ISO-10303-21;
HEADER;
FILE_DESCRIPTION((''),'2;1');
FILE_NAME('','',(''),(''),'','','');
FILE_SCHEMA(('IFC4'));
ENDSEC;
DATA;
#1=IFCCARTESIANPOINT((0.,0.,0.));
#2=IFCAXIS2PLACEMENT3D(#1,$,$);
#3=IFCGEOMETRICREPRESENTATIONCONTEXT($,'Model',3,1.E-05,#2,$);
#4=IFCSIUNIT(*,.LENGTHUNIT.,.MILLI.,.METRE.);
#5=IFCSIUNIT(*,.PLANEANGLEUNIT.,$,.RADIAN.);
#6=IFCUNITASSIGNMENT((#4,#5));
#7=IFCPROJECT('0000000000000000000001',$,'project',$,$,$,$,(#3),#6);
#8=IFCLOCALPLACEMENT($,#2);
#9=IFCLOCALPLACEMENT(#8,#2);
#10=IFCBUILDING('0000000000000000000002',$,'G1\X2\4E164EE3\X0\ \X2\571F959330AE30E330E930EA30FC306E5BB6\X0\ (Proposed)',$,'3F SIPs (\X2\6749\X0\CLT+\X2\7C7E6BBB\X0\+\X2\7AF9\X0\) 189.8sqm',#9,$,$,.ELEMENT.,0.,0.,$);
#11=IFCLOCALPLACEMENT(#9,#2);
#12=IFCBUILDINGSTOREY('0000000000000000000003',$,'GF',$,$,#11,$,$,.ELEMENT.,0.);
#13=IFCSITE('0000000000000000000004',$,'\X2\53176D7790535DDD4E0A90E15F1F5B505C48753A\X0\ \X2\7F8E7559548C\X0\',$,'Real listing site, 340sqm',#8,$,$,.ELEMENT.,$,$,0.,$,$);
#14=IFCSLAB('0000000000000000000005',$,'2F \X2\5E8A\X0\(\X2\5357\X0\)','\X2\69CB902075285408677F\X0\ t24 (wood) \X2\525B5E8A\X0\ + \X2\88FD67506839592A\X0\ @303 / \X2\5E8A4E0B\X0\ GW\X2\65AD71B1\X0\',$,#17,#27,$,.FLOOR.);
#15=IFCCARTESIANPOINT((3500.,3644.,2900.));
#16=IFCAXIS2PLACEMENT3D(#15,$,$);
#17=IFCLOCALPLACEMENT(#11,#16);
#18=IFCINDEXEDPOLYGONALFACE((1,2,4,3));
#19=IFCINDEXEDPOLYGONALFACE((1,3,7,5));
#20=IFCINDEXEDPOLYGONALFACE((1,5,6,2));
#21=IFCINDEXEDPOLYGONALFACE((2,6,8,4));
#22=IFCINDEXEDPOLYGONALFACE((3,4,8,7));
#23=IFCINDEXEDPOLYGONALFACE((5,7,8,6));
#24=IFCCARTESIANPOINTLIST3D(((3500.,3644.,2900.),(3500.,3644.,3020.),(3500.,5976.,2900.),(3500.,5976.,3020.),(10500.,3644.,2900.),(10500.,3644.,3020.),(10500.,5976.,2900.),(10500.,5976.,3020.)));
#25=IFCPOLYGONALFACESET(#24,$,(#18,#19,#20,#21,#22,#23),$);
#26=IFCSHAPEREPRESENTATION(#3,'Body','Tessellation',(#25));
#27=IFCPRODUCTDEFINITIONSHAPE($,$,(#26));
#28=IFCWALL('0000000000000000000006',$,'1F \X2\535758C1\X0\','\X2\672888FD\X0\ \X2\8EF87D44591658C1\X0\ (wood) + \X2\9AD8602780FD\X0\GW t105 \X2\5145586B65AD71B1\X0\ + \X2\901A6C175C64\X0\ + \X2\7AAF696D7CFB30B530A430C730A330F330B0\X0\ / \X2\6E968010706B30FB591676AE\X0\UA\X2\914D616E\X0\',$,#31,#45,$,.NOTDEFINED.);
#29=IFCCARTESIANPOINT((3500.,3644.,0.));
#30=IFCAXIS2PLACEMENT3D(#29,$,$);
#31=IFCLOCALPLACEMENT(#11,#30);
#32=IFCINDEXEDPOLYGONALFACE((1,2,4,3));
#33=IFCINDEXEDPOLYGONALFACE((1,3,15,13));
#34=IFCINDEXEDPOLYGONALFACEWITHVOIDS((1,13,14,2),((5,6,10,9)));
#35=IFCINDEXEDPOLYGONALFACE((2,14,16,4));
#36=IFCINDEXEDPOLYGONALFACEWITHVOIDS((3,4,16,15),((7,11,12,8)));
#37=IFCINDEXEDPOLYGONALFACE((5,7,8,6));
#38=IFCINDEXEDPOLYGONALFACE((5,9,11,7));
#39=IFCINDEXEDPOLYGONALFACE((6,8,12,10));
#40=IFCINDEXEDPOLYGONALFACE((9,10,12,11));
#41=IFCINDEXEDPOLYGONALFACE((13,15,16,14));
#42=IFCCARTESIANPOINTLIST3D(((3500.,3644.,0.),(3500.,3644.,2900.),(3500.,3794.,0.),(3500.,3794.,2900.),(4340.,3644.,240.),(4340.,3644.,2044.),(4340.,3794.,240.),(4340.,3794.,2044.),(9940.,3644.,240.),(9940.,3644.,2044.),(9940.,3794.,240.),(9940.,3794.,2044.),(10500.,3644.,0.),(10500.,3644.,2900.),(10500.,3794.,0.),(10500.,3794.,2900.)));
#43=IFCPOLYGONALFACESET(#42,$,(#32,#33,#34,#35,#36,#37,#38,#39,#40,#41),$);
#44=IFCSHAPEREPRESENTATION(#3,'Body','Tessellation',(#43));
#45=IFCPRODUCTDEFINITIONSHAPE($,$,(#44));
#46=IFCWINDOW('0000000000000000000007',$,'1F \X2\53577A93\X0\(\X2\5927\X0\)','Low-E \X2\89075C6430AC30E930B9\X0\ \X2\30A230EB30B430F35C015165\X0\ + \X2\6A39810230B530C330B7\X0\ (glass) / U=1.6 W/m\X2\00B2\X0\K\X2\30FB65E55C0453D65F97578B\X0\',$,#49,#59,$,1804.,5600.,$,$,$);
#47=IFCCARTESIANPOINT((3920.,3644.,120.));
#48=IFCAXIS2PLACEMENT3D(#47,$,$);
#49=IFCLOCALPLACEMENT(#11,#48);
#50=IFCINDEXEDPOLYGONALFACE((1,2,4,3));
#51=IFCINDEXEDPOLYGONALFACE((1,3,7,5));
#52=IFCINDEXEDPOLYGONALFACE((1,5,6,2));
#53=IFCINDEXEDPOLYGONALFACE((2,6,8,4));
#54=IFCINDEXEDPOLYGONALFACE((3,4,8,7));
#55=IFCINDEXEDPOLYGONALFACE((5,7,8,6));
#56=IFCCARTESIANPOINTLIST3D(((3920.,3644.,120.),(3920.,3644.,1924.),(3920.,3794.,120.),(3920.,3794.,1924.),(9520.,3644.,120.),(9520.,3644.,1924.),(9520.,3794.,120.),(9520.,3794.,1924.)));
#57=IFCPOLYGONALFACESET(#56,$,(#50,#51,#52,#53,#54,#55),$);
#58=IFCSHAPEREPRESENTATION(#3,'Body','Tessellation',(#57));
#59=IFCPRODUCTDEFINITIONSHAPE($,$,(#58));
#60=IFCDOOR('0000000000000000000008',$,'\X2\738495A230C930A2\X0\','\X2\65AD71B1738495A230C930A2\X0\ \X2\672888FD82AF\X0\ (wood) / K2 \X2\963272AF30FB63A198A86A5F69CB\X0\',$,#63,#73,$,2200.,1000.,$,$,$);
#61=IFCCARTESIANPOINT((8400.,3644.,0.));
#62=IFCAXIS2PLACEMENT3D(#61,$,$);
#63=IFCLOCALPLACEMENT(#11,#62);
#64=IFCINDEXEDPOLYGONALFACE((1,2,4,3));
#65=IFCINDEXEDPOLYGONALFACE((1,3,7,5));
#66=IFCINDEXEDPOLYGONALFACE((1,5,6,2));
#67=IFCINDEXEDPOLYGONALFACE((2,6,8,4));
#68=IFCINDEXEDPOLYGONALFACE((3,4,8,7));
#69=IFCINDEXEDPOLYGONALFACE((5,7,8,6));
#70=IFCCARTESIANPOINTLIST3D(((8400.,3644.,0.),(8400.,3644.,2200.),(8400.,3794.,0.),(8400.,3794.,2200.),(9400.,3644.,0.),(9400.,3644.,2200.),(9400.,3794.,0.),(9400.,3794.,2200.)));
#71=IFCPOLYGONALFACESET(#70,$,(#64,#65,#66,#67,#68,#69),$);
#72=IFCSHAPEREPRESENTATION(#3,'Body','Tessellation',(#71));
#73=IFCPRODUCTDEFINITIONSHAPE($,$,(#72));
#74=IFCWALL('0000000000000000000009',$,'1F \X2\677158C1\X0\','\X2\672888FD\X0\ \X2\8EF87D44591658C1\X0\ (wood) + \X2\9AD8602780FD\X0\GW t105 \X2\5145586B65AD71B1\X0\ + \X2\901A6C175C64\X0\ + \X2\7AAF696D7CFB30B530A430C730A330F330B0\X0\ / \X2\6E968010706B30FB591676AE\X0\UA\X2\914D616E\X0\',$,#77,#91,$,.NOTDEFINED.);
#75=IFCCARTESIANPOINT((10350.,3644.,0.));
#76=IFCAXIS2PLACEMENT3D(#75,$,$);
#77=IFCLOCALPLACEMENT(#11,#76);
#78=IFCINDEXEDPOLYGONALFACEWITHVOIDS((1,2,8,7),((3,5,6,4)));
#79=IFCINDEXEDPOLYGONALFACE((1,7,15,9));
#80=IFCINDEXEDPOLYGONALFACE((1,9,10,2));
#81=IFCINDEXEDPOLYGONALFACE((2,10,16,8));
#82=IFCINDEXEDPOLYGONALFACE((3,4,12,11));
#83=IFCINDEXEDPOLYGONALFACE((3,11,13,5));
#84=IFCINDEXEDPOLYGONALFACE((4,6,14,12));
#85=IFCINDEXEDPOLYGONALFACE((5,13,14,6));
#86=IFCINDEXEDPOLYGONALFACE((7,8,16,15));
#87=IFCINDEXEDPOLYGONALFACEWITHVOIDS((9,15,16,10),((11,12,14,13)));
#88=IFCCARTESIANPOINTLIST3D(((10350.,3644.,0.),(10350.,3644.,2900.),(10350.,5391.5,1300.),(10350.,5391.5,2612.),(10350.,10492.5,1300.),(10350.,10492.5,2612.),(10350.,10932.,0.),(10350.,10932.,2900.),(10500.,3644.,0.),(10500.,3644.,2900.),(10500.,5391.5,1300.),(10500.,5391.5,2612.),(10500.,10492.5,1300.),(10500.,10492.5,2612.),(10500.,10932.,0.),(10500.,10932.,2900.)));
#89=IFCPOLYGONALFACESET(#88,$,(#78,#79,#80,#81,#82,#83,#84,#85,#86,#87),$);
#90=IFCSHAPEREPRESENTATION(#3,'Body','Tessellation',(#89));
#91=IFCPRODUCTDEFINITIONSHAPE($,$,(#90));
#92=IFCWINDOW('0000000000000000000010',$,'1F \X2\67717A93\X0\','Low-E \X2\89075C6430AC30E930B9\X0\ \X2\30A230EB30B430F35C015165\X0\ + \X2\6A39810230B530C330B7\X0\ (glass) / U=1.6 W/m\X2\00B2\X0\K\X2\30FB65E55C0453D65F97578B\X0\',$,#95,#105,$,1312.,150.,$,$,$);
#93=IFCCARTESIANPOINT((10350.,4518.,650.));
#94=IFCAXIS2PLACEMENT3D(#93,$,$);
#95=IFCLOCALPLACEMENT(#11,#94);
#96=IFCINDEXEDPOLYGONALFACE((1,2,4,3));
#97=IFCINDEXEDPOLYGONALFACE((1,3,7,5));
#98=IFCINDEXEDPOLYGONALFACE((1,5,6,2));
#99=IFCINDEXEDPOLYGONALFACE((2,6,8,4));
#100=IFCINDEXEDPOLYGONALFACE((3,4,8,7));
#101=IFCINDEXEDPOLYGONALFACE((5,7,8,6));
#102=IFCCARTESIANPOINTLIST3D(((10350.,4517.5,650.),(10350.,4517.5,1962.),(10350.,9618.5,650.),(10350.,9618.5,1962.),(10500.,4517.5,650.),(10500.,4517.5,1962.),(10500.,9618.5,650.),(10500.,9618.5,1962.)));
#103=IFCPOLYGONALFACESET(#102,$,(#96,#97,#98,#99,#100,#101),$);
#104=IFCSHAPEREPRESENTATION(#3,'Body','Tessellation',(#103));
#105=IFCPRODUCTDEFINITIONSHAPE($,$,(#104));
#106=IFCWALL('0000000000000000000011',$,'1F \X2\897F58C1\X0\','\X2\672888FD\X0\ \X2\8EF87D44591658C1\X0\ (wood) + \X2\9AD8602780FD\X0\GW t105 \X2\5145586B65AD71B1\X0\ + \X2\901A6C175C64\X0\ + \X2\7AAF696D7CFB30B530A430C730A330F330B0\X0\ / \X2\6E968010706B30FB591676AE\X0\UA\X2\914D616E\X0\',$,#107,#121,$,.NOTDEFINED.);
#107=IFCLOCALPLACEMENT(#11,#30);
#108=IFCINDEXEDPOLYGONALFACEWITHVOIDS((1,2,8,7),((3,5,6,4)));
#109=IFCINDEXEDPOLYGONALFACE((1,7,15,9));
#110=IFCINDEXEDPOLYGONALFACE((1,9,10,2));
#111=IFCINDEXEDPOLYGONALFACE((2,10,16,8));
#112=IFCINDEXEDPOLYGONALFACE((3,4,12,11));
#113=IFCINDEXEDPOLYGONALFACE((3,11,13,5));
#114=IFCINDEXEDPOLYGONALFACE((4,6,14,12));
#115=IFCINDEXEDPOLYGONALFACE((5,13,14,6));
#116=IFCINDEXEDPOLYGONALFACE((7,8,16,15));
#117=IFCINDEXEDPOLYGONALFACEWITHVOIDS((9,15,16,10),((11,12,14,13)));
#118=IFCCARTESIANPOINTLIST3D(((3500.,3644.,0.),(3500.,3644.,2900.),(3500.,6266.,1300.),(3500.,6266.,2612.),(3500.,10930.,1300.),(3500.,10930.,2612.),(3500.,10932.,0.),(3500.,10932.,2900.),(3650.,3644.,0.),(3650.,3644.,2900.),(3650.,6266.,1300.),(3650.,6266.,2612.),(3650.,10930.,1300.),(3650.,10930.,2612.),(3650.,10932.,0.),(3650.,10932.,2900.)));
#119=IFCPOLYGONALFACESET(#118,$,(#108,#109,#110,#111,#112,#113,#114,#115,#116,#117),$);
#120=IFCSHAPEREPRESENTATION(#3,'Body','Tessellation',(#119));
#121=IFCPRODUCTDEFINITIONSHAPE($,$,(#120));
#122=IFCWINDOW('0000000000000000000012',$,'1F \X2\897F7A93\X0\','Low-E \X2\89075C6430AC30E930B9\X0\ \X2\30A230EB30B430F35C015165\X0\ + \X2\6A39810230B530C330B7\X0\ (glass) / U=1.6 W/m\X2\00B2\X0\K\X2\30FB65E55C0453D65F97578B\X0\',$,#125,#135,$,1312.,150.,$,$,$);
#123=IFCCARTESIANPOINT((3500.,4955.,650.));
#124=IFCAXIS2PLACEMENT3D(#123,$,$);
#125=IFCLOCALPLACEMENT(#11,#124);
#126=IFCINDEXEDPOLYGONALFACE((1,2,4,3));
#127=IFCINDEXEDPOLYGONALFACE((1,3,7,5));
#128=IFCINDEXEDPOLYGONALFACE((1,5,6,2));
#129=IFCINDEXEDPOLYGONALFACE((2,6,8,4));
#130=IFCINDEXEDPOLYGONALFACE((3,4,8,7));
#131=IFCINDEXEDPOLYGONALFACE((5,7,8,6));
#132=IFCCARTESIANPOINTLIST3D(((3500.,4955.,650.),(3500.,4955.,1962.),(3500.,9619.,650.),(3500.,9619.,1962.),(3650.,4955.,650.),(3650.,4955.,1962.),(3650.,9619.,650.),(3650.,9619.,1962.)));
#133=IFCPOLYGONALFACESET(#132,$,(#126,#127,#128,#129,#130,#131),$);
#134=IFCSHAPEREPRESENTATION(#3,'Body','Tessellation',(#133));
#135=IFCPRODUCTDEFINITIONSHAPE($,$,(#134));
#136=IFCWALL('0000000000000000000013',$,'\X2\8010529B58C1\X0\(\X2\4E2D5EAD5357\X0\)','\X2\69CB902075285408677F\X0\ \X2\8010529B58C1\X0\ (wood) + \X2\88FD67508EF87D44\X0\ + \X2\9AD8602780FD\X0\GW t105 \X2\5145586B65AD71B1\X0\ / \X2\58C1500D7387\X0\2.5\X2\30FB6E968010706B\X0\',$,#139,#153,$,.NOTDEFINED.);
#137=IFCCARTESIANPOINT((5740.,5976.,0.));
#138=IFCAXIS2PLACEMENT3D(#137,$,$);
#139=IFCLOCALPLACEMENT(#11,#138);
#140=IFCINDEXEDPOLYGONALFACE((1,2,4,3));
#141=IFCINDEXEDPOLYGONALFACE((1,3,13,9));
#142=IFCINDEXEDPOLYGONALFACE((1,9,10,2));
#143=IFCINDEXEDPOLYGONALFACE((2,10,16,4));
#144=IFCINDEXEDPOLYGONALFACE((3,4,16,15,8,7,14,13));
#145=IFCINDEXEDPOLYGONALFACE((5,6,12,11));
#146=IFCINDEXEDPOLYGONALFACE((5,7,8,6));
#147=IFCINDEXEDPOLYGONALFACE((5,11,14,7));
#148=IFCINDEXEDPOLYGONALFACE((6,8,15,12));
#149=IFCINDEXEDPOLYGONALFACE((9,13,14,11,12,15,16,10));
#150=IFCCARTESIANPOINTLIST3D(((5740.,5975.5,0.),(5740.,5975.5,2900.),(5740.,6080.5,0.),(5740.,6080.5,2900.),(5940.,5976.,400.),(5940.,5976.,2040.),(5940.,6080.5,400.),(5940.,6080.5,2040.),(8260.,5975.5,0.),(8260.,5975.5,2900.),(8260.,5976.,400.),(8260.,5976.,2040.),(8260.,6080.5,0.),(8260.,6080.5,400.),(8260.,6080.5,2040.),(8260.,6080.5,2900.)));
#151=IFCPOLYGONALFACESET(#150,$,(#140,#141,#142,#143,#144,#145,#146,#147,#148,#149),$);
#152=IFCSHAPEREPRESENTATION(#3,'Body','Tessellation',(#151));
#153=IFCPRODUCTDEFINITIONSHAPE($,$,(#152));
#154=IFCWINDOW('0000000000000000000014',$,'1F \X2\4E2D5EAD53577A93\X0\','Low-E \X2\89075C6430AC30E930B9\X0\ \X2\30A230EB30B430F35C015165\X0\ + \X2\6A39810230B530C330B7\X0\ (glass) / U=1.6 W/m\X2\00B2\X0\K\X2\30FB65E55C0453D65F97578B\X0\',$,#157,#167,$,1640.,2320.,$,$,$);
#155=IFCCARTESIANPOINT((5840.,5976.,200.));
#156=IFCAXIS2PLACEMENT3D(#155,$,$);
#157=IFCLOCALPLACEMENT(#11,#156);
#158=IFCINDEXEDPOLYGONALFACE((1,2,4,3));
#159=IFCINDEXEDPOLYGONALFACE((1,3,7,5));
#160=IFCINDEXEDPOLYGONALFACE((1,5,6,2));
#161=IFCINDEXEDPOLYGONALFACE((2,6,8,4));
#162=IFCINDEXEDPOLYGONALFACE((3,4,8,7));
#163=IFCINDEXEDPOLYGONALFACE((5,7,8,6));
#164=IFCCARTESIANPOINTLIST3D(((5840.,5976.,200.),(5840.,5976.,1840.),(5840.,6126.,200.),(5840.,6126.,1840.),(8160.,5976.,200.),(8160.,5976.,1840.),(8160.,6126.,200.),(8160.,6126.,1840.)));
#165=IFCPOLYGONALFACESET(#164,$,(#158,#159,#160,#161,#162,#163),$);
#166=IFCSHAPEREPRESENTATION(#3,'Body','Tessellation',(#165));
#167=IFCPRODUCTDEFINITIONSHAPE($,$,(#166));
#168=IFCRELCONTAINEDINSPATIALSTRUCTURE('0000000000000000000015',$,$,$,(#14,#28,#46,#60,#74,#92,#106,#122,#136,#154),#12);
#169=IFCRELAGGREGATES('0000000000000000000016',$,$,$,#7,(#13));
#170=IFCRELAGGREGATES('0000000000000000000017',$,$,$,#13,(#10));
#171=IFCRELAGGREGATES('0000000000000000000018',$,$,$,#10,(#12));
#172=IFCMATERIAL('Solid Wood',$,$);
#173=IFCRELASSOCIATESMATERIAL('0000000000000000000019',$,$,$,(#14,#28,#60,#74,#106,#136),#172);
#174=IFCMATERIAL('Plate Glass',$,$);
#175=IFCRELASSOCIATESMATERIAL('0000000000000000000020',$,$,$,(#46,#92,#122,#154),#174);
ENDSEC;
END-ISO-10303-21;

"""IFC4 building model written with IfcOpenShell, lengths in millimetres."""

from ifc_helpers import new_model, si_unit, frame, frame_2d, origin, place, context, project, spatial, rectangle, extrude, material, element, fill, save


model = new_model("IFC4")

# Units and contexts
model_context = context("Model", 3, precision=1e-05, world=origin())
ifc_project = project(units=[si_unit("LENGTHUNIT", "METRE", prefix="MILLI"), si_unit("PLANEANGLEUNIT", "RADIAN")], contexts=[model_context])

# Site, building, storey
site_placement = place(None, origin())
site = spatial("IfcSite", under=ifc_project, at=site_placement, Name="北海道川上郡弟子屈町 美留和", ObjectType="Real listing site, 340sqm", CompositionType="ELEMENT", RefElevation=0.0)
building_placement = place(site_placement, origin())
building = spatial("IfcBuilding", under=site, at=building_placement, Name="G1世代 土間ギャラリーの家 (Proposed)", ObjectType="3F SIPs (杉CLT+籾殻+竹) 189.8sqm", CompositionType="ELEMENT", ElevationOfRefHeight=0.0, ElevationOfTerrain=0.0)
storey_placement = place(building_placement, origin())
storey = spatial("IfcBuildingStorey", under=building, at=storey_placement, Name="GF", CompositionType="ELEMENT", Elevation=0.0)

# Slab
ifc_material_1 = material(Name="Solid Wood")
slab_1_placement = place(storey_placement, frame((3500.0, 3644.0, 2900.0)))
element("IfcSlab", 1, at=slab_1_placement, inside=storey, material=ifc_material_1, Name="2F 床(南)", Description="構造用合板 t24 (wood) 剛床 + 製材根太 @303 / 床下 GW断熱", PredefinedType="FLOOR", context=model_context, shape_type="SweptSolid", body=[
    extrude(rectangle(XDim=7000.0, YDim=2332.0, at=frame_2d((3500.0, 1166.0))), frame((3500.0, 3644.0, 2900.0)), (0.0, 0.0, 1.0), 120.0),
])

# Wall, openings, window, door
wall_1_placement = place(storey_placement, frame((3500.0, 3644.0, 0.0)))
wall_1 = element("IfcWall", 2, at=wall_1_placement, inside=storey, material=ifc_material_1, Name="1F 南壁", Description="木製 軸組外壁 (wood) + 高性能GW t105 充填断熱 + 通気層 + 窯業系サイディング / 準耐火・外皮UA配慮", PredefinedType="NOTDEFINED", context=model_context, shape_type="SweptSolid", body=[
    extrude(rectangle(XDim=7000.0, YDim=150.0, at=frame_2d((3500.0, 75.0))), frame((3500.0, 3644.0, 0.0)), (0.0, 0.0, 1.0), 2900.0),
])
opening_1_placement = place(storey_placement, frame((3920.0, 3644.0, 120.0)))
opening_1 = element("IfcOpeningElement", 3, at=opening_1_placement, cuts=wall_1, PredefinedType="NOTDEFINED", context=model_context, shape_type="SweptSolid", body=[
    extrude(rectangle(XDim=5600.0, YDim=150.0, at=frame_2d((2800.0, 75.0))), frame((3920.0, 3644.0, 120.0)), (0.0, 0.0, 1.0), 1804.0),
])
opening_2_placement = place(storey_placement, frame((8400.0, 3644.0, 0.0)))
opening_2 = element("IfcOpeningElement", 4, at=opening_2_placement, cuts=wall_1, PredefinedType="NOTDEFINED", context=model_context, shape_type="SweptSolid", body=[
    extrude(rectangle(XDim=1000.0, YDim=150.0, at=frame_2d((500.0, 75.0))), frame((8400.0, 3644.0, 0.0)), (0.0, 0.0, 1.0), 2200.0),
])
ifc_material_2 = material(Name="Plate Glass")
window_1_placement = place(storey_placement, frame((3920.0, 3644.0, 120.0)))
window_1 = element("IfcWindow", 5, at=window_1_placement, inside=storey, material=ifc_material_2, Name="1F 南窓(大)", Description="Low-E 複層ガラス アルゴン封入 + 樹脂サッシ (glass) / U=1.6 W/m²K・日射取得型", OverallHeight=1804.0, OverallWidth=5600.0, context=model_context, shape_type="SweptSolid", body=[
    extrude(rectangle(XDim=5600.0, YDim=150.0, at=frame_2d((2800.0, 75.0))), frame((3920.0, 3644.0, 120.0)), (0.0, 0.0, 1.0), 1804.0),
])
fill(opening_1, window_1)
door_placement = place(storey_placement, frame((8400.0, 3644.0, 0.0)))
door = element("IfcDoor", 6, at=door_placement, inside=storey, material=ifc_material_1, Name="玄関ドア", Description="断熱玄関ドア 木製芯 (wood) / K2 防犯・採風機構", OverallHeight=2200.0, OverallWidth=1000.0, context=model_context, shape_type="SweptSolid", body=[
    extrude(rectangle(XDim=1000.0, YDim=150.0, at=frame_2d((500.0, 75.0))), frame((8400.0, 3644.0, 0.0)), (0.0, 0.0, 1.0), 2200.0),
])
fill(opening_2, door)

# Walls, openings, windows
wall_2_placement = place(storey_placement, frame((10350.0, 3644.0, 0.0)))
wall_2 = element("IfcWall", 7, at=wall_2_placement, inside=storey, material=ifc_material_1, Name="1F 東壁", Description="木製 軸組外壁 (wood) + 高性能GW t105 充填断熱 + 通気層 + 窯業系サイディング / 準耐火・外皮UA配慮", PredefinedType="NOTDEFINED", context=model_context, shape_type="SweptSolid", body=[
    extrude(rectangle(XDim=150.0, YDim=7288.0, at=frame_2d((75.0, 3644.0))), frame((10350.0, 3644.0, 0.0)), (0.0, 0.0, 1.0), 2900.0),
])
opening_3_placement = place(storey_placement, frame((10350.0, 4518.0, 650.0)))
opening_3 = element("IfcOpeningElement", 8, at=opening_3_placement, cuts=wall_2, PredefinedType="NOTDEFINED", context=model_context, shape_type="SweptSolid", body=[
    extrude(rectangle(XDim=150.0, YDim=5101.0, at=frame_2d((75.0, 2550.0))), frame((10350.0, 4518.0, 650.0)), (0.0, 0.0, 1.0), 1312.0),
])
window_2_placement = place(storey_placement, frame((10350.0, 4518.0, 650.0)))
window_2 = element("IfcWindow", 9, at=window_2_placement, inside=storey, material=ifc_material_2, Name="1F 東窓", Description="Low-E 複層ガラス アルゴン封入 + 樹脂サッシ (glass) / U=1.6 W/m²K・日射取得型", OverallHeight=1312.0, OverallWidth=150.0, context=model_context, shape_type="SweptSolid", body=[
    extrude(rectangle(XDim=150.0, YDim=5101.0, at=frame_2d((75.0, 2550.0))), frame((10350.0, 4518.0, 650.0)), (0.0, 0.0, 1.0), 1312.0),
])
fill(opening_3, window_2)
wall_3_placement = place(storey_placement, frame((3500.0, 3644.0, 0.0)))
wall_3 = element("IfcWall", 10, at=wall_3_placement, inside=storey, material=ifc_material_1, Name="1F 西壁", Description="木製 軸組外壁 (wood) + 高性能GW t105 充填断熱 + 通気層 + 窯業系サイディング / 準耐火・外皮UA配慮", PredefinedType="NOTDEFINED", context=model_context, shape_type="SweptSolid", body=[
    extrude(rectangle(XDim=150.0, YDim=7288.0, at=frame_2d((75.0, 3644.0))), frame((3500.0, 3644.0, 0.0)), (0.0, 0.0, 1.0), 2900.0),
])
opening_4_placement = place(storey_placement, frame((3500.0, 4955.0, 650.0)))
opening_4 = element("IfcOpeningElement", 11, at=opening_4_placement, cuts=wall_3, PredefinedType="NOTDEFINED", context=model_context, shape_type="SweptSolid", body=[
    extrude(rectangle(XDim=150.0, YDim=4664.0, at=frame_2d((75.0, 2332.0))), frame((3500.0, 4955.0, 650.0)), (0.0, 0.0, 1.0), 1312.0),
])
window_3_placement = place(storey_placement, frame((3500.0, 4955.0, 650.0)))
window_3 = element("IfcWindow", 12, at=window_3_placement, inside=storey, material=ifc_material_2, Name="1F 西窓", Description="Low-E 複層ガラス アルゴン封入 + 樹脂サッシ (glass) / U=1.6 W/m²K・日射取得型", OverallHeight=1312.0, OverallWidth=150.0, context=model_context, shape_type="SweptSolid", body=[
    extrude(rectangle(XDim=150.0, YDim=4664.0, at=frame_2d((75.0, 2332.0))), frame((3500.0, 4955.0, 650.0)), (0.0, 0.0, 1.0), 1312.0),
])
fill(opening_4, window_3)
wall_4_placement = place(storey_placement, frame((5740.0, 5976.0, 0.0)))
wall_4 = element("IfcWall", 13, at=wall_4_placement, inside=storey, material=ifc_material_1, Name="耐力壁(中庭南)", Description="構造用合板 耐力壁 (wood) + 製材軸組 + 高性能GW t105 充填断熱 / 壁倍率2.5・準耐火", PredefinedType="NOTDEFINED", context=model_context, shape_type="SweptSolid", body=[
    extrude(rectangle(XDim=2520.0, YDim=105.0, at=frame_2d((1260.0, 52.0))), frame((5740.0, 5976.0, 0.0)), (0.0, 0.0, 1.0), 2900.0),
])
opening_5_placement = place(storey_placement, frame((5840.0, 5976.0, 200.0)))
opening_5 = element("IfcOpeningElement", 14, at=opening_5_placement, cuts=wall_4, PredefinedType="NOTDEFINED", context=model_context, shape_type="SweptSolid", body=[
    extrude(rectangle(XDim=2320.0, YDim=150.0, at=frame_2d((1160.0, 75.0))), frame((5840.0, 5976.0, 200.0)), (0.0, 0.0, 1.0), 1640.0),
])
window_4_placement = place(storey_placement, frame((5840.0, 5976.0, 200.0)))
window_4 = element("IfcWindow", 15, at=window_4_placement, inside=storey, material=ifc_material_2, Name="1F 中庭南窓", Description="Low-E 複層ガラス アルゴン封入 + 樹脂サッシ (glass) / U=1.6 W/m²K・日射取得型", OverallHeight=1640.0, OverallWidth=2320.0, context=model_context, shape_type="SweptSolid", body=[
    extrude(rectangle(XDim=2320.0, YDim=150.0, at=frame_2d((1160.0, 75.0))), frame((5840.0, 5976.0, 200.0)), (0.0, 0.0, 1.0), 1640.0),
])
fill(opening_5, window_4)

save(model, "model.ifc")
